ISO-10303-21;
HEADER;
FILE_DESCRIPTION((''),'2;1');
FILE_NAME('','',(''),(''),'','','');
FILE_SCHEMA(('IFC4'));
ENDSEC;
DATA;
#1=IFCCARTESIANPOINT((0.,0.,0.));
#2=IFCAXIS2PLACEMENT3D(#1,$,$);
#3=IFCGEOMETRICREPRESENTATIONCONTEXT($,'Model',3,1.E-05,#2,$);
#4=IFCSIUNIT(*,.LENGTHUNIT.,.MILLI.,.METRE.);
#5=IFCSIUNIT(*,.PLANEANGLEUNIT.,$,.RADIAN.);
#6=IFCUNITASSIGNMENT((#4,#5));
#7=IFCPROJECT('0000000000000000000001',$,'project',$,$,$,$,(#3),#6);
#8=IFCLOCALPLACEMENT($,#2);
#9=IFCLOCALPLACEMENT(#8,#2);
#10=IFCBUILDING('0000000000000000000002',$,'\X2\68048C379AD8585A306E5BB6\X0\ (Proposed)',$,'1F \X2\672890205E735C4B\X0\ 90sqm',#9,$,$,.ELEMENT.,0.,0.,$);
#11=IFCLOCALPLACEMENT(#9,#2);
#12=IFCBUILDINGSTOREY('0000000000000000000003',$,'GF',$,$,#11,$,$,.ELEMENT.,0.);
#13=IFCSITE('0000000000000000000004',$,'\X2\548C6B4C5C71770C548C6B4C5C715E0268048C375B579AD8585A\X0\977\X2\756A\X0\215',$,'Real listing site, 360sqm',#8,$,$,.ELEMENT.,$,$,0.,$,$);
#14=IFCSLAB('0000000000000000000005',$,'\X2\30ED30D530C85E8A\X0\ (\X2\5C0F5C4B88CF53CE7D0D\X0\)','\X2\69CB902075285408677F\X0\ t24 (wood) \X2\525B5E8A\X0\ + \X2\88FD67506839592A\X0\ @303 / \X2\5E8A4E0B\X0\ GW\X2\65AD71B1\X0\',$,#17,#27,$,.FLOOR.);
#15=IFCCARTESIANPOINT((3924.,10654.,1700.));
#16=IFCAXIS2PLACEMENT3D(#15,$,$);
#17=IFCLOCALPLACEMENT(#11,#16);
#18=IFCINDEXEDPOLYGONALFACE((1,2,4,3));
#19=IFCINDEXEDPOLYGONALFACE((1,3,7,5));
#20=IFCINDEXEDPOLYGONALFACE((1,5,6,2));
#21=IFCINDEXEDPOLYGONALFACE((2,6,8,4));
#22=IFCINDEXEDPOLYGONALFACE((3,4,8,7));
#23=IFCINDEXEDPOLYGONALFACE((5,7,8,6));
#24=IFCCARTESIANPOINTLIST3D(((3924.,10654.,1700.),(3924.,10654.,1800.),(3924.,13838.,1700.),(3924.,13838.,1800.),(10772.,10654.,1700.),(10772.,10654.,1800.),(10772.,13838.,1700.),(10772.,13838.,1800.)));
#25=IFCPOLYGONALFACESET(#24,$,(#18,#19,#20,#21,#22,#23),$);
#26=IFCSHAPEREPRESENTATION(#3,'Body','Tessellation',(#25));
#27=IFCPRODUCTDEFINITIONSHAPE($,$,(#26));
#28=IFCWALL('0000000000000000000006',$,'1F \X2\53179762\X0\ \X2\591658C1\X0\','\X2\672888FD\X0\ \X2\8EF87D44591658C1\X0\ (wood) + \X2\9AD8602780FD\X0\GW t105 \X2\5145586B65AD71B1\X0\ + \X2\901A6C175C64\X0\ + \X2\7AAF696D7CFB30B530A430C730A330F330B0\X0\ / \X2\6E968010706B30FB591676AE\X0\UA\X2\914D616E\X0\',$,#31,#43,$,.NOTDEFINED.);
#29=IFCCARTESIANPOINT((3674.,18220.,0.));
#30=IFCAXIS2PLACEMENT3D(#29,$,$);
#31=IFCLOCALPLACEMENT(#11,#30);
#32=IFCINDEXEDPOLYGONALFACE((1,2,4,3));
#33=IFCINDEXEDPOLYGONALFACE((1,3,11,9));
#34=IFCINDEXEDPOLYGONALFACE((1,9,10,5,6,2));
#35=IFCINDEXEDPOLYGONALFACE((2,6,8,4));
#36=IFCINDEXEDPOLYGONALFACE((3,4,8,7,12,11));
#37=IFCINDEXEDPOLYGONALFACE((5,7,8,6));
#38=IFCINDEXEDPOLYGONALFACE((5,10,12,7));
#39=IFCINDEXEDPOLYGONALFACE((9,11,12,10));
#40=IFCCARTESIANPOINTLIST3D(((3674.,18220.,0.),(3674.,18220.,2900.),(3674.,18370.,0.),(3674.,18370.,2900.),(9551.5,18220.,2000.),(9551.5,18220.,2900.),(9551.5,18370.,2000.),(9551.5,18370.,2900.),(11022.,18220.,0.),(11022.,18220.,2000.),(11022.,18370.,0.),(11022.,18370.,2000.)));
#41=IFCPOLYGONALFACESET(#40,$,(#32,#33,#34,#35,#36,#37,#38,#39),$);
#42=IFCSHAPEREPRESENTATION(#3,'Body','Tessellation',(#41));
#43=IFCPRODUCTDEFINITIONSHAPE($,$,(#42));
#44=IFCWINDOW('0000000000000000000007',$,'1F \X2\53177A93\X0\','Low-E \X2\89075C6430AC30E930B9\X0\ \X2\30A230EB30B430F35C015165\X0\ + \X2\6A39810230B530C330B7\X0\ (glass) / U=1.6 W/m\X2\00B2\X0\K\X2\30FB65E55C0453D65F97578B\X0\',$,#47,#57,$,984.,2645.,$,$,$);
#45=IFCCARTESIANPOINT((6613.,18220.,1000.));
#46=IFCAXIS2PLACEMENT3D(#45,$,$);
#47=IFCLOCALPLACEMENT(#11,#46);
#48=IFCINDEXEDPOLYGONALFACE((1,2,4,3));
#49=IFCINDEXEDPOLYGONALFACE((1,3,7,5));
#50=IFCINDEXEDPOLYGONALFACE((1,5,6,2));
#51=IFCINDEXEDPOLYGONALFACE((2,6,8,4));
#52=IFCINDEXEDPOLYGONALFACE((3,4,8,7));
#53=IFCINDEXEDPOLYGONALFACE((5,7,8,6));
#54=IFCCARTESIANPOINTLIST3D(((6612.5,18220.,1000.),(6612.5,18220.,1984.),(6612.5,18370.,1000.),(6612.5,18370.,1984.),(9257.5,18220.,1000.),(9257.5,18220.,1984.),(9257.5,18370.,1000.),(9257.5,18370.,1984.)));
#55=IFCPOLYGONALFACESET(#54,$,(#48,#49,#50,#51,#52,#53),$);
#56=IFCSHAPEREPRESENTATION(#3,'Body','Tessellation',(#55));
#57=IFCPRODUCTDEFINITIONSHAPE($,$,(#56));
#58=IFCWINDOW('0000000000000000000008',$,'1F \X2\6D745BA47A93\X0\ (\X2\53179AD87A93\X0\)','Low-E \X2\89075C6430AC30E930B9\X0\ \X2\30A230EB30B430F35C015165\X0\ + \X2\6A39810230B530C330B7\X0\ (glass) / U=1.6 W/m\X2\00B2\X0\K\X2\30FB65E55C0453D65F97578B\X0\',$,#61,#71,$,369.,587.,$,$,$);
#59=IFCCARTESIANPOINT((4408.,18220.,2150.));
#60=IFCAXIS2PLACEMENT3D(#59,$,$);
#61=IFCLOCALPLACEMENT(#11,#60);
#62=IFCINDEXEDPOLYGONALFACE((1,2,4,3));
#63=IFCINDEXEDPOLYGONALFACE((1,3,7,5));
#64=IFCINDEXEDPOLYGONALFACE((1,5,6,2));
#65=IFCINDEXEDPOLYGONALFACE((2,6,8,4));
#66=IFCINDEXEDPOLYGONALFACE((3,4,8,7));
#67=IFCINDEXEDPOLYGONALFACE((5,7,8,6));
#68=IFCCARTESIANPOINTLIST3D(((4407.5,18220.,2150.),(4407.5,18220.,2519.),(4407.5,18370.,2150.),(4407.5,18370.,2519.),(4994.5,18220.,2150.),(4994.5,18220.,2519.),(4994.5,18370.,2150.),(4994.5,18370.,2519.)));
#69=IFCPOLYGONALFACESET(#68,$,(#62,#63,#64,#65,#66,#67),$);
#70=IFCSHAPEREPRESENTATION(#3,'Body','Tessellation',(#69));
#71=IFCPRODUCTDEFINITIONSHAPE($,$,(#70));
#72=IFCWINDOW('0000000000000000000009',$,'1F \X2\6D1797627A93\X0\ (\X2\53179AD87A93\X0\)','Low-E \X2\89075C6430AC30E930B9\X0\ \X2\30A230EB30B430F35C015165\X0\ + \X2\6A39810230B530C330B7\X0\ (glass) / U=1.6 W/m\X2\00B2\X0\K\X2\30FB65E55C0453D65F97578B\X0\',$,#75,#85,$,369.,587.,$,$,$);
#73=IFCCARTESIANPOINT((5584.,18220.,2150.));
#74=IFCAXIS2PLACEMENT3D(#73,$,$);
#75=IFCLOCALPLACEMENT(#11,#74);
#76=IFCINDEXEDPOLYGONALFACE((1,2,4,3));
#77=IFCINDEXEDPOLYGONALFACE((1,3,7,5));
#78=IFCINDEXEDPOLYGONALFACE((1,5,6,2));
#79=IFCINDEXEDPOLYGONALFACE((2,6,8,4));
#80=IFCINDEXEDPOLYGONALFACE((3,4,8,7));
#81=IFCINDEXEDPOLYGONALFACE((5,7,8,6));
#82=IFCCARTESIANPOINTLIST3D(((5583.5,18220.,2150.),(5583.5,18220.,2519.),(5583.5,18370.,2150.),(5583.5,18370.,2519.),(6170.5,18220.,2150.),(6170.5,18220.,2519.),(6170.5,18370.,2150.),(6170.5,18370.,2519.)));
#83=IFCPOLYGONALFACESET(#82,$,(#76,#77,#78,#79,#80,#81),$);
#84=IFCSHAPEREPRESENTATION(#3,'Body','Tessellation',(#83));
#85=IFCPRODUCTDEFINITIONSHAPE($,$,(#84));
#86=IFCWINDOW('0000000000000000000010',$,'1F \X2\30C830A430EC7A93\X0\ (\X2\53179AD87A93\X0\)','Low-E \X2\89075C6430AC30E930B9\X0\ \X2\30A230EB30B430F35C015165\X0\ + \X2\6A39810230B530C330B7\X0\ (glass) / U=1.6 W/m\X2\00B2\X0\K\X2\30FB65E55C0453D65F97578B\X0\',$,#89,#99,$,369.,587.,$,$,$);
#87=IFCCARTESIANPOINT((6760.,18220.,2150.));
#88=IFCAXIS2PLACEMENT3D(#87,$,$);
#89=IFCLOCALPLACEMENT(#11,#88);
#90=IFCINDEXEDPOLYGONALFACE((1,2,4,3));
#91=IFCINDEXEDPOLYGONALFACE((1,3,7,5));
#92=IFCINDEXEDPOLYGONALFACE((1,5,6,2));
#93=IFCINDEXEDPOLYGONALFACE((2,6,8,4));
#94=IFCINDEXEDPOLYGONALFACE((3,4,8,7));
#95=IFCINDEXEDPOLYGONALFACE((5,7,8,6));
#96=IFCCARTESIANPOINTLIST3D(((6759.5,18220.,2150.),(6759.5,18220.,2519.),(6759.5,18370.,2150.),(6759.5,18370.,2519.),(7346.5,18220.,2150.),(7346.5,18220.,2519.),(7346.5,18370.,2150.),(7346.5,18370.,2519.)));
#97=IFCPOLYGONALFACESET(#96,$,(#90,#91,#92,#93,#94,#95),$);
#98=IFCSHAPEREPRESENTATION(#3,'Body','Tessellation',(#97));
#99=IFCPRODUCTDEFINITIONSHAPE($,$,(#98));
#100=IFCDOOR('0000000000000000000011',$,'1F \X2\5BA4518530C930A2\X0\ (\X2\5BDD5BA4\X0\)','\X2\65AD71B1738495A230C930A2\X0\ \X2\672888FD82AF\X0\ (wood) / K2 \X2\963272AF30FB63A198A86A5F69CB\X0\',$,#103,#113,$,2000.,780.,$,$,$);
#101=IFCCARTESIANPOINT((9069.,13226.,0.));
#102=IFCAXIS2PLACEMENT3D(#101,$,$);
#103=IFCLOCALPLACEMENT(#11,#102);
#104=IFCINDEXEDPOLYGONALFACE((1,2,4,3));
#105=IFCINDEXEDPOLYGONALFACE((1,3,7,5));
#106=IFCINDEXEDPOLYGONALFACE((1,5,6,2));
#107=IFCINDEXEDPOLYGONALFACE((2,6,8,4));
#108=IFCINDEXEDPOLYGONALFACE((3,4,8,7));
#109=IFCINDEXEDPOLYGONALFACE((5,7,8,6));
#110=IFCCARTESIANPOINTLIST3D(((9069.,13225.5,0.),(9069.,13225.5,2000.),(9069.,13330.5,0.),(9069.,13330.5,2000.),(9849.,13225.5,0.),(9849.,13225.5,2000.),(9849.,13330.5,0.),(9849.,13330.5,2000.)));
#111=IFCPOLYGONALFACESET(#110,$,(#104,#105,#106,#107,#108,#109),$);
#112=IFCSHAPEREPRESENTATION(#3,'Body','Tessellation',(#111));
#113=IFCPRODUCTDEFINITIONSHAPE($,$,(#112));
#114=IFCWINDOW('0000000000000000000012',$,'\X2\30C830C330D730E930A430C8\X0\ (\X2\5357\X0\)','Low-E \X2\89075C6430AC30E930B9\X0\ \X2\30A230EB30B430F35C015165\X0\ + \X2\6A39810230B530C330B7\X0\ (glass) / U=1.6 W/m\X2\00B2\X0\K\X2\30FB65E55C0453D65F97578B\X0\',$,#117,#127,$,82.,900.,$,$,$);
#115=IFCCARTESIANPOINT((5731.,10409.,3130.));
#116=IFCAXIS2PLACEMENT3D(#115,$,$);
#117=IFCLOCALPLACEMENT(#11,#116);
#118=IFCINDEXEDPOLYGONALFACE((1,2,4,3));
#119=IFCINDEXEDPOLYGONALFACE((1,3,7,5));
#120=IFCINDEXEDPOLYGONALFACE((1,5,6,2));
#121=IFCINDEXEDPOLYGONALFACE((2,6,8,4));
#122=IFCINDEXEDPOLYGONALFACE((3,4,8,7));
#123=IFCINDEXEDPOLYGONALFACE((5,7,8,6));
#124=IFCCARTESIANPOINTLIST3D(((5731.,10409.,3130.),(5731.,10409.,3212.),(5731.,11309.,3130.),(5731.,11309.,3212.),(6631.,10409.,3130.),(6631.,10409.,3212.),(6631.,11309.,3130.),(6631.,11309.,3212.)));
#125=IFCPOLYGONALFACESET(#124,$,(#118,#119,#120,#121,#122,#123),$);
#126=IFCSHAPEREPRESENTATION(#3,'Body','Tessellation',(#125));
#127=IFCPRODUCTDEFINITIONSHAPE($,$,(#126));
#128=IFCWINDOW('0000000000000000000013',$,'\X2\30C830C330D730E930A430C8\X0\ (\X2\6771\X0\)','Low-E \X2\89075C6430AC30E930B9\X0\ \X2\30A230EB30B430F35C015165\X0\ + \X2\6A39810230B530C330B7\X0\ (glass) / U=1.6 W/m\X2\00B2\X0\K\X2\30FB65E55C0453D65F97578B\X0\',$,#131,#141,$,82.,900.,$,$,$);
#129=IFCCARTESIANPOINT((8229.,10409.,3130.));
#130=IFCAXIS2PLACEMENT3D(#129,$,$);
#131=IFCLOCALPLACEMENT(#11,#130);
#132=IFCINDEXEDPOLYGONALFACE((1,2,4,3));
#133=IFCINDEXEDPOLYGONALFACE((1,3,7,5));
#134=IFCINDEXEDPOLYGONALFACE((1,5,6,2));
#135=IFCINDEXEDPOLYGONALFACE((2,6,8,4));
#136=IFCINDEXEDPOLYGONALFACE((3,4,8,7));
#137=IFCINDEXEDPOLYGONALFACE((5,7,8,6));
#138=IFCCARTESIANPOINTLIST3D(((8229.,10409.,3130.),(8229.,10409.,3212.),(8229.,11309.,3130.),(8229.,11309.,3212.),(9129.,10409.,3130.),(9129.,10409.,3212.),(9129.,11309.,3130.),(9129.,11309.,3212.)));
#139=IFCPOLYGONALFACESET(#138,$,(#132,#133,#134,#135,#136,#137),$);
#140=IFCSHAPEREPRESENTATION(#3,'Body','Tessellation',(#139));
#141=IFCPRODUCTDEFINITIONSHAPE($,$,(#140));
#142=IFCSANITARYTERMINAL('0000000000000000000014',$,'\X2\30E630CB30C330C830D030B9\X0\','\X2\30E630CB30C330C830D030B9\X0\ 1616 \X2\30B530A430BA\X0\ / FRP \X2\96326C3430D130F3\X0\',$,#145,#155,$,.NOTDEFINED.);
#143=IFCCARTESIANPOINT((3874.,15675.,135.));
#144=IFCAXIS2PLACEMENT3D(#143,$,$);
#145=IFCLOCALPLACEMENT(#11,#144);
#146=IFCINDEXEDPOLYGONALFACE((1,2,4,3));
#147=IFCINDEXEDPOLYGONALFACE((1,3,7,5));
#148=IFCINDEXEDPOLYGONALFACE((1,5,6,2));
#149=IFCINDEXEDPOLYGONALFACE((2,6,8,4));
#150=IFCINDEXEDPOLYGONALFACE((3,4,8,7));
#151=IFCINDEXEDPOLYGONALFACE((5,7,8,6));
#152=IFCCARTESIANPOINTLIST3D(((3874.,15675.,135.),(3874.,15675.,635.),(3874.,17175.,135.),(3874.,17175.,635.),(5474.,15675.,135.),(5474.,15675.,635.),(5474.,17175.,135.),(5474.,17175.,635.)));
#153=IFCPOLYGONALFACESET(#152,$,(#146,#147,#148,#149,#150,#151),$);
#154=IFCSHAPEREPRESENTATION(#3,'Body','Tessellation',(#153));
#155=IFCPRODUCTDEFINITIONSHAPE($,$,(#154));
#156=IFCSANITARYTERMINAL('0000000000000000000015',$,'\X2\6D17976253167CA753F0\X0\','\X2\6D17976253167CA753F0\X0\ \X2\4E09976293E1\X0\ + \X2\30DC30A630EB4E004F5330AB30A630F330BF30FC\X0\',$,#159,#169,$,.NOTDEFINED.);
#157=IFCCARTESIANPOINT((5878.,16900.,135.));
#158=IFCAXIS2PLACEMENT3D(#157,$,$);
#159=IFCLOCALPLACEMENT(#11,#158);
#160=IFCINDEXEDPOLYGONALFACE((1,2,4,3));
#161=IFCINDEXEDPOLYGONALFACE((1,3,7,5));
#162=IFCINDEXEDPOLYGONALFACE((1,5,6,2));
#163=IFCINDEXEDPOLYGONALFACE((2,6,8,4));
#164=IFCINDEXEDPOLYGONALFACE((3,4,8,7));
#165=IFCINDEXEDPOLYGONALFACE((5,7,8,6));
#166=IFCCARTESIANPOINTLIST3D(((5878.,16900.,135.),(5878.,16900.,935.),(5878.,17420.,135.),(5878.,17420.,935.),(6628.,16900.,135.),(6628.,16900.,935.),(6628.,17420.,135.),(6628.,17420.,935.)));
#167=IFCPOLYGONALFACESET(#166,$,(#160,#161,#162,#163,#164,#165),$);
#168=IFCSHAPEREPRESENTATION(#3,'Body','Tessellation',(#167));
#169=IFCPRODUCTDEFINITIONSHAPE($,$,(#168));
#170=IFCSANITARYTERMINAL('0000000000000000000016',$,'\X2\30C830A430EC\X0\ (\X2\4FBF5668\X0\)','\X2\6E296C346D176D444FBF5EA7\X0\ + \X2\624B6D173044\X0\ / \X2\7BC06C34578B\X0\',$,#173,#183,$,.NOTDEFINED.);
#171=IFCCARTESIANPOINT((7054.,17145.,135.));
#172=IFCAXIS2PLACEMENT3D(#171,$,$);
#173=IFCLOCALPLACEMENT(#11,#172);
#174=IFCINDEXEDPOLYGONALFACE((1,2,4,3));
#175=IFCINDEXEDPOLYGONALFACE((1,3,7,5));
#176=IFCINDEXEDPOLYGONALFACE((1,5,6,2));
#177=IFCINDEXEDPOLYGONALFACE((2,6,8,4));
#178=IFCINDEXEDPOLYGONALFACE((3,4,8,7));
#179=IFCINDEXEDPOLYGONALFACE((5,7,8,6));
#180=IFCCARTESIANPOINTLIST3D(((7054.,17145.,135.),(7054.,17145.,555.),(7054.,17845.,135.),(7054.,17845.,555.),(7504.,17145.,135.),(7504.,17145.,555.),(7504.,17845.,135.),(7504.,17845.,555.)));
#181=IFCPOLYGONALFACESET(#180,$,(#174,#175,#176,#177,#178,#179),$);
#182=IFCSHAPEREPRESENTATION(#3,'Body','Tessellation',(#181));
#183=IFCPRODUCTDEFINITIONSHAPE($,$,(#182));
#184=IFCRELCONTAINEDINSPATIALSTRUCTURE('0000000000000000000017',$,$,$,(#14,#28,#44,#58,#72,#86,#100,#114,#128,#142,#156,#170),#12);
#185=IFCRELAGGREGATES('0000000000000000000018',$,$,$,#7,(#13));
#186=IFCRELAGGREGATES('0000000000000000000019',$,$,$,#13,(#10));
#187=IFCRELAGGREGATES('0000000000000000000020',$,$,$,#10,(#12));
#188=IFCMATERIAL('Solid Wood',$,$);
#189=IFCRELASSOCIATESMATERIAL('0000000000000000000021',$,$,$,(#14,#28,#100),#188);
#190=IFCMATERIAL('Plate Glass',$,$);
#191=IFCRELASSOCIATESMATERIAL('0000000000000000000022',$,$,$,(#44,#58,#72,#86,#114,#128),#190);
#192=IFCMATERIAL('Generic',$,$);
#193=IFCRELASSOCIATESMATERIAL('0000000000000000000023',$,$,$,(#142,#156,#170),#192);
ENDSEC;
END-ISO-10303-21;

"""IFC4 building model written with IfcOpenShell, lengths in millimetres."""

from ifc_helpers import new_model, si_unit, frame, frame_2d, origin, place, context, project, spatial, rectangle, extrude, material, element, fill, save


model = new_model("IFC4")

# Units and contexts
model_context = context("Model", 3, precision=1e-05, world=origin())
ifc_project = project(units=[si_unit("LENGTHUNIT", "METRE", prefix="MILLI"), si_unit("PLANEANGLEUNIT", "RADIAN")], contexts=[model_context])

# Site, building, storey
site_placement = place(None, origin())
site = spatial("IfcSite", under=ifc_project, at=site_placement, Name="和歌山県和歌山市栄谷字高塚977番215", ObjectType="Real listing site, 360sqm", CompositionType="ELEMENT", RefElevation=0.0)
building_placement = place(site_placement, origin())
building = spatial("IfcBuilding", under=site, at=building_placement, Name="栄谷高塚の家 (Proposed)", ObjectType="1F 木造平屋 90sqm", CompositionType="ELEMENT", ElevationOfRefHeight=0.0, ElevationOfTerrain=0.0)
storey_placement = place(building_placement, origin())
storey = spatial("IfcBuildingStorey", under=building, at=storey_placement, Name="GF", CompositionType="ELEMENT", Elevation=0.0)

# Slab
ifc_material_1 = material(Name="Solid Wood")
slab_placement = place(storey_placement, frame((3924.0, 10654.0, 1700.0)))
element("IfcSlab", 1, at=slab_placement, inside=storey, material=ifc_material_1, Name="ロフト床 (小屋裏収納)", Description="構造用合板 t24 (wood) 剛床 + 製材根太 @303 / 床下 GW断熱", PredefinedType="FLOOR", context=model_context, shape_type="SweptSolid", body=[
    extrude(rectangle(XDim=6848.0, YDim=3184.0, at=frame_2d((3424.0, 1592.0))), frame((3924.0, 10654.0, 1700.0)), (0.0, 0.0, 1.0), 100.0),
])

# Wall, openings, windows
wall_1_placement = place(storey_placement, frame((3674.0, 18220.0, 0.0)))
wall_1 = element("IfcWall", 2, at=wall_1_placement, inside=storey, material=ifc_material_1, Name="1F 北面 外壁", Description="木製 軸組外壁 (wood) + 高性能GW t105 充填断熱 + 通気層 + 窯業系サイディング / 準耐火・外皮UA配慮", PredefinedType="NOTDEFINED", context=model_context, shape_type="SweptSolid", body=[
    extrude(rectangle(XDim=7348.0, YDim=150.0, at=frame_2d((3674.0, 75.0))), frame((3674.0, 18220.0, 0.0)), (0.0, 0.0, 1.0), 2900.0),
])
opening_1_placement = place(storey_placement, frame((6613.0, 18220.0, 1000.0)))
opening_1 = element("IfcOpeningElement", 3, at=opening_1_placement, cuts=wall_1, PredefinedType="NOTDEFINED", context=model_context, shape_type="SweptSolid", body=[
    extrude(rectangle(XDim=2645.0, YDim=150.0, at=frame_2d((1322.0, 75.0))), frame((6613.0, 18220.0, 1000.0)), (0.0, 0.0, 1.0), 984.0),
])
opening_2_placement = place(storey_placement, frame((4408.0, 18220.0, 2150.0)))
opening_2 = element("IfcOpeningElement", 4, at=opening_2_placement, cuts=wall_1, PredefinedType="NOTDEFINED", context=model_context, shape_type="SweptSolid", body=[
    extrude(rectangle(XDim=587.0, YDim=150.0, at=frame_2d((293.0, 75.0))), frame((4408.0, 18220.0, 2150.0)), (0.0, 0.0, 1.0), 369.0),
])
opening_3_placement = place(storey_placement, frame((5584.0, 18220.0, 2150.0)))
opening_3 = element("IfcOpeningElement", 5, at=opening_3_placement, cuts=wall_1, PredefinedType="NOTDEFINED", context=model_context, shape_type="SweptSolid", body=[
    extrude(rectangle(XDim=587.0, YDim=150.0, at=frame_2d((293.0, 75.0))), frame((5584.0, 18220.0, 2150.0)), (0.0, 0.0, 1.0), 369.0),
])
opening_4_placement = place(storey_placement, frame((6760.0, 18220.0, 2150.0)))
opening_4 = element("IfcOpeningElement", 6, at=opening_4_placement, cuts=wall_1, PredefinedType="NOTDEFINED", context=model_context, shape_type="SweptSolid", body=[
    extrude(rectangle(XDim=587.0, YDim=150.0, at=frame_2d((293.0, 75.0))), frame((6760.0, 18220.0, 2150.0)), (0.0, 0.0, 1.0), 369.0),
])
ifc_material_2 = material(Name="Plate Glass")
window_1_placement = place(storey_placement, frame((6613.0, 18220.0, 1000.0)))
window_1 = element("IfcWindow", 7, at=window_1_placement, inside=storey, material=ifc_material_2, Name="1F 北窓", Description="Low-E 複層ガラス アルゴン封入 + 樹脂サッシ (glass) / U=1.6 W/m²K・日射取得型", OverallHeight=984.0, OverallWidth=2645.0, context=model_context, shape_type="SweptSolid", body=[
    extrude(rectangle(XDim=2645.0, YDim=150.0, at=frame_2d((1322.0, 75.0))), frame((6613.0, 18220.0, 1000.0)), (0.0, 0.0, 1.0), 984.0),
])
fill(opening_1, window_1)
window_2_placement = place(storey_placement, frame((4408.0, 18220.0, 2150.0)))
window_2 = element("IfcWindow", 8, at=window_2_placement, inside=storey, material=ifc_material_2, Name="1F 浴室窓 (北高窓)", Description="Low-E 複層ガラス アルゴン封入 + 樹脂サッシ (glass) / U=1.6 W/m²K・日射取得型", OverallHeight=369.0, OverallWidth=587.0, context=model_context, shape_type="SweptSolid", body=[
    extrude(rectangle(XDim=587.0, YDim=150.0, at=frame_2d((293.0, 75.0))), frame((4408.0, 18220.0, 2150.0)), (0.0, 0.0, 1.0), 369.0),
])
fill(opening_2, window_2)
window_3_placement = place(storey_placement, frame((5584.0, 18220.0, 2150.0)))
window_3 = element("IfcWindow", 9, at=window_3_placement, inside=storey, material=ifc_material_2, Name="1F 洗面窓 (北高窓)", Description="Low-E 複層ガラス アルゴン封入 + 樹脂サッシ (glass) / U=1.6 W/m²K・日射取得型", OverallHeight=369.0, OverallWidth=587.0, context=model_context, shape_type="SweptSolid", body=[
    extrude(rectangle(XDim=587.0, YDim=150.0, at=frame_2d((293.0, 75.0))), frame((5584.0, 18220.0, 2150.0)), (0.0, 0.0, 1.0), 369.0),
])
fill(opening_3, window_3)
window_4_placement = place(storey_placement, frame((6760.0, 18220.0, 2150.0)))
window_4 = element("IfcWindow", 10, at=window_4_placement, inside=storey, material=ifc_material_2, Name="1F トイレ窓 (北高窓)", Description="Low-E 複層ガラス アルゴン封入 + 樹脂サッシ (glass) / U=1.6 W/m²K・日射取得型", OverallHeight=369.0, OverallWidth=587.0, context=model_context, shape_type="SweptSolid", body=[
    extrude(rectangle(XDim=587.0, YDim=150.0, at=frame_2d((293.0, 75.0))), frame((6760.0, 18220.0, 2150.0)), (0.0, 0.0, 1.0), 369.0),
])
fill(opening_4, window_4)

# Door
door_1_placement = place(storey_placement, frame((9069.0, 13226.0, 0.0)))
element("IfcDoor", 11, at=door_1_placement, inside=storey, material=ifc_material_1, Name="1F 室内ドア (寝室)", Description="断熱玄関ドア 木製芯 (wood) / K2 防犯・採風機構", OverallHeight=2000.0, OverallWidth=780.0, context=model_context, shape_type="SweptSolid", body=[
    extrude(rectangle(XDim=780.0, YDim=105.0, at=frame_2d((390.0, 52.0))), frame((9069.0, 13226.0, 0.0)), (0.0, 0.0, 1.0), 2000.0),
])

# Windows
window_5_placement = place(storey_placement, frame((5731.0, 10409.0, 3130.0)))
element("IfcWindow", 12, at=window_5_placement, inside=storey, material=ifc_material_2, Name="トップライト (南)", Description="Low-E 複層ガラス アルゴン封入 + 樹脂サッシ (glass) / U=1.6 W/m²K・日射取得型", OverallHeight=82.0, OverallWidth=900.0, context=model_context, shape_type="SweptSolid", body=[
    extrude(rectangle(XDim=900.0, YDim=900.0, at=frame_2d((450.0, 450.0))), frame((5731.0, 10409.0, 3130.0)), (0.0, 0.0, 1.0), 82.0),
])
window_6_placement = place(storey_placement, frame((8229.0, 10409.0, 3130.0)))
element("IfcWindow", 13, at=window_6_placement, inside=storey, material=ifc_material_2, Name="トップライト (東)", Description="Low-E 複層ガラス アルゴン封入 + 樹脂サッシ (glass) / U=1.6 W/m²K・日射取得型", OverallHeight=82.0, OverallWidth=900.0, context=model_context, shape_type="SweptSolid", body=[
    extrude(rectangle(XDim=900.0, YDim=900.0, at=frame_2d((450.0, 450.0))), frame((8229.0, 10409.0, 3130.0)), (0.0, 0.0, 1.0), 82.0),
])

# Sanitary terminals
ifc_material_3 = material(Name="Generic")
sanitary_terminal_1_placement = place(storey_placement, frame((3874.0, 15675.0, 135.0)))
element("IfcSanitaryTerminal", 14, at=sanitary_terminal_1_placement, inside=storey, material=ifc_material_3, Name="ユニットバス", Description="ユニットバス 1616 サイズ / FRP 防水パン", PredefinedType="NOTDEFINED", context=model_context, shape_type="SweptSolid", body=[
    extrude(rectangle(XDim=1600.0, YDim=1500.0, at=frame_2d((800.0, 750.0))), frame((3874.0, 15675.0, 135.0)), (0.0, 0.0, 1.0), 500.0),
])
sanitary_terminal_2_placement = place(storey_placement, frame((5878.0, 16900.0, 135.0)))
element("IfcSanitaryTerminal", 15, at=sanitary_terminal_2_placement, inside=storey, material=ifc_material_3, Name="洗面化粧台", Description="洗面化粧台 三面鏡 + ボウル一体カウンター", PredefinedType="NOTDEFINED", context=model_context, shape_type="SweptSolid", body=[
    extrude(rectangle(XDim=750.0, YDim=520.0, at=frame_2d((375.0, 260.0))), frame((5878.0, 16900.0, 135.0)), (0.0, 0.0, 1.0), 800.0),
])
sanitary_terminal_3_placement = place(storey_placement, frame((7054.0, 17145.0, 135.0)))
element("IfcSanitaryTerminal", 16, at=sanitary_terminal_3_placement, inside=storey, material=ifc_material_3, Name="トイレ (便器)", Description="温水洗浄便座 + 手洗い / 節水型", PredefinedType="NOTDEFINED", context=model_context, shape_type="SweptSolid", body=[
    extrude(rectangle(XDim=450.0, YDim=700.0, at=frame_2d((225.0, 350.0))), frame((7054.0, 17145.0, 135.0)), (0.0, 0.0, 1.0), 420.0),
])

save(model, "model.ifc")
